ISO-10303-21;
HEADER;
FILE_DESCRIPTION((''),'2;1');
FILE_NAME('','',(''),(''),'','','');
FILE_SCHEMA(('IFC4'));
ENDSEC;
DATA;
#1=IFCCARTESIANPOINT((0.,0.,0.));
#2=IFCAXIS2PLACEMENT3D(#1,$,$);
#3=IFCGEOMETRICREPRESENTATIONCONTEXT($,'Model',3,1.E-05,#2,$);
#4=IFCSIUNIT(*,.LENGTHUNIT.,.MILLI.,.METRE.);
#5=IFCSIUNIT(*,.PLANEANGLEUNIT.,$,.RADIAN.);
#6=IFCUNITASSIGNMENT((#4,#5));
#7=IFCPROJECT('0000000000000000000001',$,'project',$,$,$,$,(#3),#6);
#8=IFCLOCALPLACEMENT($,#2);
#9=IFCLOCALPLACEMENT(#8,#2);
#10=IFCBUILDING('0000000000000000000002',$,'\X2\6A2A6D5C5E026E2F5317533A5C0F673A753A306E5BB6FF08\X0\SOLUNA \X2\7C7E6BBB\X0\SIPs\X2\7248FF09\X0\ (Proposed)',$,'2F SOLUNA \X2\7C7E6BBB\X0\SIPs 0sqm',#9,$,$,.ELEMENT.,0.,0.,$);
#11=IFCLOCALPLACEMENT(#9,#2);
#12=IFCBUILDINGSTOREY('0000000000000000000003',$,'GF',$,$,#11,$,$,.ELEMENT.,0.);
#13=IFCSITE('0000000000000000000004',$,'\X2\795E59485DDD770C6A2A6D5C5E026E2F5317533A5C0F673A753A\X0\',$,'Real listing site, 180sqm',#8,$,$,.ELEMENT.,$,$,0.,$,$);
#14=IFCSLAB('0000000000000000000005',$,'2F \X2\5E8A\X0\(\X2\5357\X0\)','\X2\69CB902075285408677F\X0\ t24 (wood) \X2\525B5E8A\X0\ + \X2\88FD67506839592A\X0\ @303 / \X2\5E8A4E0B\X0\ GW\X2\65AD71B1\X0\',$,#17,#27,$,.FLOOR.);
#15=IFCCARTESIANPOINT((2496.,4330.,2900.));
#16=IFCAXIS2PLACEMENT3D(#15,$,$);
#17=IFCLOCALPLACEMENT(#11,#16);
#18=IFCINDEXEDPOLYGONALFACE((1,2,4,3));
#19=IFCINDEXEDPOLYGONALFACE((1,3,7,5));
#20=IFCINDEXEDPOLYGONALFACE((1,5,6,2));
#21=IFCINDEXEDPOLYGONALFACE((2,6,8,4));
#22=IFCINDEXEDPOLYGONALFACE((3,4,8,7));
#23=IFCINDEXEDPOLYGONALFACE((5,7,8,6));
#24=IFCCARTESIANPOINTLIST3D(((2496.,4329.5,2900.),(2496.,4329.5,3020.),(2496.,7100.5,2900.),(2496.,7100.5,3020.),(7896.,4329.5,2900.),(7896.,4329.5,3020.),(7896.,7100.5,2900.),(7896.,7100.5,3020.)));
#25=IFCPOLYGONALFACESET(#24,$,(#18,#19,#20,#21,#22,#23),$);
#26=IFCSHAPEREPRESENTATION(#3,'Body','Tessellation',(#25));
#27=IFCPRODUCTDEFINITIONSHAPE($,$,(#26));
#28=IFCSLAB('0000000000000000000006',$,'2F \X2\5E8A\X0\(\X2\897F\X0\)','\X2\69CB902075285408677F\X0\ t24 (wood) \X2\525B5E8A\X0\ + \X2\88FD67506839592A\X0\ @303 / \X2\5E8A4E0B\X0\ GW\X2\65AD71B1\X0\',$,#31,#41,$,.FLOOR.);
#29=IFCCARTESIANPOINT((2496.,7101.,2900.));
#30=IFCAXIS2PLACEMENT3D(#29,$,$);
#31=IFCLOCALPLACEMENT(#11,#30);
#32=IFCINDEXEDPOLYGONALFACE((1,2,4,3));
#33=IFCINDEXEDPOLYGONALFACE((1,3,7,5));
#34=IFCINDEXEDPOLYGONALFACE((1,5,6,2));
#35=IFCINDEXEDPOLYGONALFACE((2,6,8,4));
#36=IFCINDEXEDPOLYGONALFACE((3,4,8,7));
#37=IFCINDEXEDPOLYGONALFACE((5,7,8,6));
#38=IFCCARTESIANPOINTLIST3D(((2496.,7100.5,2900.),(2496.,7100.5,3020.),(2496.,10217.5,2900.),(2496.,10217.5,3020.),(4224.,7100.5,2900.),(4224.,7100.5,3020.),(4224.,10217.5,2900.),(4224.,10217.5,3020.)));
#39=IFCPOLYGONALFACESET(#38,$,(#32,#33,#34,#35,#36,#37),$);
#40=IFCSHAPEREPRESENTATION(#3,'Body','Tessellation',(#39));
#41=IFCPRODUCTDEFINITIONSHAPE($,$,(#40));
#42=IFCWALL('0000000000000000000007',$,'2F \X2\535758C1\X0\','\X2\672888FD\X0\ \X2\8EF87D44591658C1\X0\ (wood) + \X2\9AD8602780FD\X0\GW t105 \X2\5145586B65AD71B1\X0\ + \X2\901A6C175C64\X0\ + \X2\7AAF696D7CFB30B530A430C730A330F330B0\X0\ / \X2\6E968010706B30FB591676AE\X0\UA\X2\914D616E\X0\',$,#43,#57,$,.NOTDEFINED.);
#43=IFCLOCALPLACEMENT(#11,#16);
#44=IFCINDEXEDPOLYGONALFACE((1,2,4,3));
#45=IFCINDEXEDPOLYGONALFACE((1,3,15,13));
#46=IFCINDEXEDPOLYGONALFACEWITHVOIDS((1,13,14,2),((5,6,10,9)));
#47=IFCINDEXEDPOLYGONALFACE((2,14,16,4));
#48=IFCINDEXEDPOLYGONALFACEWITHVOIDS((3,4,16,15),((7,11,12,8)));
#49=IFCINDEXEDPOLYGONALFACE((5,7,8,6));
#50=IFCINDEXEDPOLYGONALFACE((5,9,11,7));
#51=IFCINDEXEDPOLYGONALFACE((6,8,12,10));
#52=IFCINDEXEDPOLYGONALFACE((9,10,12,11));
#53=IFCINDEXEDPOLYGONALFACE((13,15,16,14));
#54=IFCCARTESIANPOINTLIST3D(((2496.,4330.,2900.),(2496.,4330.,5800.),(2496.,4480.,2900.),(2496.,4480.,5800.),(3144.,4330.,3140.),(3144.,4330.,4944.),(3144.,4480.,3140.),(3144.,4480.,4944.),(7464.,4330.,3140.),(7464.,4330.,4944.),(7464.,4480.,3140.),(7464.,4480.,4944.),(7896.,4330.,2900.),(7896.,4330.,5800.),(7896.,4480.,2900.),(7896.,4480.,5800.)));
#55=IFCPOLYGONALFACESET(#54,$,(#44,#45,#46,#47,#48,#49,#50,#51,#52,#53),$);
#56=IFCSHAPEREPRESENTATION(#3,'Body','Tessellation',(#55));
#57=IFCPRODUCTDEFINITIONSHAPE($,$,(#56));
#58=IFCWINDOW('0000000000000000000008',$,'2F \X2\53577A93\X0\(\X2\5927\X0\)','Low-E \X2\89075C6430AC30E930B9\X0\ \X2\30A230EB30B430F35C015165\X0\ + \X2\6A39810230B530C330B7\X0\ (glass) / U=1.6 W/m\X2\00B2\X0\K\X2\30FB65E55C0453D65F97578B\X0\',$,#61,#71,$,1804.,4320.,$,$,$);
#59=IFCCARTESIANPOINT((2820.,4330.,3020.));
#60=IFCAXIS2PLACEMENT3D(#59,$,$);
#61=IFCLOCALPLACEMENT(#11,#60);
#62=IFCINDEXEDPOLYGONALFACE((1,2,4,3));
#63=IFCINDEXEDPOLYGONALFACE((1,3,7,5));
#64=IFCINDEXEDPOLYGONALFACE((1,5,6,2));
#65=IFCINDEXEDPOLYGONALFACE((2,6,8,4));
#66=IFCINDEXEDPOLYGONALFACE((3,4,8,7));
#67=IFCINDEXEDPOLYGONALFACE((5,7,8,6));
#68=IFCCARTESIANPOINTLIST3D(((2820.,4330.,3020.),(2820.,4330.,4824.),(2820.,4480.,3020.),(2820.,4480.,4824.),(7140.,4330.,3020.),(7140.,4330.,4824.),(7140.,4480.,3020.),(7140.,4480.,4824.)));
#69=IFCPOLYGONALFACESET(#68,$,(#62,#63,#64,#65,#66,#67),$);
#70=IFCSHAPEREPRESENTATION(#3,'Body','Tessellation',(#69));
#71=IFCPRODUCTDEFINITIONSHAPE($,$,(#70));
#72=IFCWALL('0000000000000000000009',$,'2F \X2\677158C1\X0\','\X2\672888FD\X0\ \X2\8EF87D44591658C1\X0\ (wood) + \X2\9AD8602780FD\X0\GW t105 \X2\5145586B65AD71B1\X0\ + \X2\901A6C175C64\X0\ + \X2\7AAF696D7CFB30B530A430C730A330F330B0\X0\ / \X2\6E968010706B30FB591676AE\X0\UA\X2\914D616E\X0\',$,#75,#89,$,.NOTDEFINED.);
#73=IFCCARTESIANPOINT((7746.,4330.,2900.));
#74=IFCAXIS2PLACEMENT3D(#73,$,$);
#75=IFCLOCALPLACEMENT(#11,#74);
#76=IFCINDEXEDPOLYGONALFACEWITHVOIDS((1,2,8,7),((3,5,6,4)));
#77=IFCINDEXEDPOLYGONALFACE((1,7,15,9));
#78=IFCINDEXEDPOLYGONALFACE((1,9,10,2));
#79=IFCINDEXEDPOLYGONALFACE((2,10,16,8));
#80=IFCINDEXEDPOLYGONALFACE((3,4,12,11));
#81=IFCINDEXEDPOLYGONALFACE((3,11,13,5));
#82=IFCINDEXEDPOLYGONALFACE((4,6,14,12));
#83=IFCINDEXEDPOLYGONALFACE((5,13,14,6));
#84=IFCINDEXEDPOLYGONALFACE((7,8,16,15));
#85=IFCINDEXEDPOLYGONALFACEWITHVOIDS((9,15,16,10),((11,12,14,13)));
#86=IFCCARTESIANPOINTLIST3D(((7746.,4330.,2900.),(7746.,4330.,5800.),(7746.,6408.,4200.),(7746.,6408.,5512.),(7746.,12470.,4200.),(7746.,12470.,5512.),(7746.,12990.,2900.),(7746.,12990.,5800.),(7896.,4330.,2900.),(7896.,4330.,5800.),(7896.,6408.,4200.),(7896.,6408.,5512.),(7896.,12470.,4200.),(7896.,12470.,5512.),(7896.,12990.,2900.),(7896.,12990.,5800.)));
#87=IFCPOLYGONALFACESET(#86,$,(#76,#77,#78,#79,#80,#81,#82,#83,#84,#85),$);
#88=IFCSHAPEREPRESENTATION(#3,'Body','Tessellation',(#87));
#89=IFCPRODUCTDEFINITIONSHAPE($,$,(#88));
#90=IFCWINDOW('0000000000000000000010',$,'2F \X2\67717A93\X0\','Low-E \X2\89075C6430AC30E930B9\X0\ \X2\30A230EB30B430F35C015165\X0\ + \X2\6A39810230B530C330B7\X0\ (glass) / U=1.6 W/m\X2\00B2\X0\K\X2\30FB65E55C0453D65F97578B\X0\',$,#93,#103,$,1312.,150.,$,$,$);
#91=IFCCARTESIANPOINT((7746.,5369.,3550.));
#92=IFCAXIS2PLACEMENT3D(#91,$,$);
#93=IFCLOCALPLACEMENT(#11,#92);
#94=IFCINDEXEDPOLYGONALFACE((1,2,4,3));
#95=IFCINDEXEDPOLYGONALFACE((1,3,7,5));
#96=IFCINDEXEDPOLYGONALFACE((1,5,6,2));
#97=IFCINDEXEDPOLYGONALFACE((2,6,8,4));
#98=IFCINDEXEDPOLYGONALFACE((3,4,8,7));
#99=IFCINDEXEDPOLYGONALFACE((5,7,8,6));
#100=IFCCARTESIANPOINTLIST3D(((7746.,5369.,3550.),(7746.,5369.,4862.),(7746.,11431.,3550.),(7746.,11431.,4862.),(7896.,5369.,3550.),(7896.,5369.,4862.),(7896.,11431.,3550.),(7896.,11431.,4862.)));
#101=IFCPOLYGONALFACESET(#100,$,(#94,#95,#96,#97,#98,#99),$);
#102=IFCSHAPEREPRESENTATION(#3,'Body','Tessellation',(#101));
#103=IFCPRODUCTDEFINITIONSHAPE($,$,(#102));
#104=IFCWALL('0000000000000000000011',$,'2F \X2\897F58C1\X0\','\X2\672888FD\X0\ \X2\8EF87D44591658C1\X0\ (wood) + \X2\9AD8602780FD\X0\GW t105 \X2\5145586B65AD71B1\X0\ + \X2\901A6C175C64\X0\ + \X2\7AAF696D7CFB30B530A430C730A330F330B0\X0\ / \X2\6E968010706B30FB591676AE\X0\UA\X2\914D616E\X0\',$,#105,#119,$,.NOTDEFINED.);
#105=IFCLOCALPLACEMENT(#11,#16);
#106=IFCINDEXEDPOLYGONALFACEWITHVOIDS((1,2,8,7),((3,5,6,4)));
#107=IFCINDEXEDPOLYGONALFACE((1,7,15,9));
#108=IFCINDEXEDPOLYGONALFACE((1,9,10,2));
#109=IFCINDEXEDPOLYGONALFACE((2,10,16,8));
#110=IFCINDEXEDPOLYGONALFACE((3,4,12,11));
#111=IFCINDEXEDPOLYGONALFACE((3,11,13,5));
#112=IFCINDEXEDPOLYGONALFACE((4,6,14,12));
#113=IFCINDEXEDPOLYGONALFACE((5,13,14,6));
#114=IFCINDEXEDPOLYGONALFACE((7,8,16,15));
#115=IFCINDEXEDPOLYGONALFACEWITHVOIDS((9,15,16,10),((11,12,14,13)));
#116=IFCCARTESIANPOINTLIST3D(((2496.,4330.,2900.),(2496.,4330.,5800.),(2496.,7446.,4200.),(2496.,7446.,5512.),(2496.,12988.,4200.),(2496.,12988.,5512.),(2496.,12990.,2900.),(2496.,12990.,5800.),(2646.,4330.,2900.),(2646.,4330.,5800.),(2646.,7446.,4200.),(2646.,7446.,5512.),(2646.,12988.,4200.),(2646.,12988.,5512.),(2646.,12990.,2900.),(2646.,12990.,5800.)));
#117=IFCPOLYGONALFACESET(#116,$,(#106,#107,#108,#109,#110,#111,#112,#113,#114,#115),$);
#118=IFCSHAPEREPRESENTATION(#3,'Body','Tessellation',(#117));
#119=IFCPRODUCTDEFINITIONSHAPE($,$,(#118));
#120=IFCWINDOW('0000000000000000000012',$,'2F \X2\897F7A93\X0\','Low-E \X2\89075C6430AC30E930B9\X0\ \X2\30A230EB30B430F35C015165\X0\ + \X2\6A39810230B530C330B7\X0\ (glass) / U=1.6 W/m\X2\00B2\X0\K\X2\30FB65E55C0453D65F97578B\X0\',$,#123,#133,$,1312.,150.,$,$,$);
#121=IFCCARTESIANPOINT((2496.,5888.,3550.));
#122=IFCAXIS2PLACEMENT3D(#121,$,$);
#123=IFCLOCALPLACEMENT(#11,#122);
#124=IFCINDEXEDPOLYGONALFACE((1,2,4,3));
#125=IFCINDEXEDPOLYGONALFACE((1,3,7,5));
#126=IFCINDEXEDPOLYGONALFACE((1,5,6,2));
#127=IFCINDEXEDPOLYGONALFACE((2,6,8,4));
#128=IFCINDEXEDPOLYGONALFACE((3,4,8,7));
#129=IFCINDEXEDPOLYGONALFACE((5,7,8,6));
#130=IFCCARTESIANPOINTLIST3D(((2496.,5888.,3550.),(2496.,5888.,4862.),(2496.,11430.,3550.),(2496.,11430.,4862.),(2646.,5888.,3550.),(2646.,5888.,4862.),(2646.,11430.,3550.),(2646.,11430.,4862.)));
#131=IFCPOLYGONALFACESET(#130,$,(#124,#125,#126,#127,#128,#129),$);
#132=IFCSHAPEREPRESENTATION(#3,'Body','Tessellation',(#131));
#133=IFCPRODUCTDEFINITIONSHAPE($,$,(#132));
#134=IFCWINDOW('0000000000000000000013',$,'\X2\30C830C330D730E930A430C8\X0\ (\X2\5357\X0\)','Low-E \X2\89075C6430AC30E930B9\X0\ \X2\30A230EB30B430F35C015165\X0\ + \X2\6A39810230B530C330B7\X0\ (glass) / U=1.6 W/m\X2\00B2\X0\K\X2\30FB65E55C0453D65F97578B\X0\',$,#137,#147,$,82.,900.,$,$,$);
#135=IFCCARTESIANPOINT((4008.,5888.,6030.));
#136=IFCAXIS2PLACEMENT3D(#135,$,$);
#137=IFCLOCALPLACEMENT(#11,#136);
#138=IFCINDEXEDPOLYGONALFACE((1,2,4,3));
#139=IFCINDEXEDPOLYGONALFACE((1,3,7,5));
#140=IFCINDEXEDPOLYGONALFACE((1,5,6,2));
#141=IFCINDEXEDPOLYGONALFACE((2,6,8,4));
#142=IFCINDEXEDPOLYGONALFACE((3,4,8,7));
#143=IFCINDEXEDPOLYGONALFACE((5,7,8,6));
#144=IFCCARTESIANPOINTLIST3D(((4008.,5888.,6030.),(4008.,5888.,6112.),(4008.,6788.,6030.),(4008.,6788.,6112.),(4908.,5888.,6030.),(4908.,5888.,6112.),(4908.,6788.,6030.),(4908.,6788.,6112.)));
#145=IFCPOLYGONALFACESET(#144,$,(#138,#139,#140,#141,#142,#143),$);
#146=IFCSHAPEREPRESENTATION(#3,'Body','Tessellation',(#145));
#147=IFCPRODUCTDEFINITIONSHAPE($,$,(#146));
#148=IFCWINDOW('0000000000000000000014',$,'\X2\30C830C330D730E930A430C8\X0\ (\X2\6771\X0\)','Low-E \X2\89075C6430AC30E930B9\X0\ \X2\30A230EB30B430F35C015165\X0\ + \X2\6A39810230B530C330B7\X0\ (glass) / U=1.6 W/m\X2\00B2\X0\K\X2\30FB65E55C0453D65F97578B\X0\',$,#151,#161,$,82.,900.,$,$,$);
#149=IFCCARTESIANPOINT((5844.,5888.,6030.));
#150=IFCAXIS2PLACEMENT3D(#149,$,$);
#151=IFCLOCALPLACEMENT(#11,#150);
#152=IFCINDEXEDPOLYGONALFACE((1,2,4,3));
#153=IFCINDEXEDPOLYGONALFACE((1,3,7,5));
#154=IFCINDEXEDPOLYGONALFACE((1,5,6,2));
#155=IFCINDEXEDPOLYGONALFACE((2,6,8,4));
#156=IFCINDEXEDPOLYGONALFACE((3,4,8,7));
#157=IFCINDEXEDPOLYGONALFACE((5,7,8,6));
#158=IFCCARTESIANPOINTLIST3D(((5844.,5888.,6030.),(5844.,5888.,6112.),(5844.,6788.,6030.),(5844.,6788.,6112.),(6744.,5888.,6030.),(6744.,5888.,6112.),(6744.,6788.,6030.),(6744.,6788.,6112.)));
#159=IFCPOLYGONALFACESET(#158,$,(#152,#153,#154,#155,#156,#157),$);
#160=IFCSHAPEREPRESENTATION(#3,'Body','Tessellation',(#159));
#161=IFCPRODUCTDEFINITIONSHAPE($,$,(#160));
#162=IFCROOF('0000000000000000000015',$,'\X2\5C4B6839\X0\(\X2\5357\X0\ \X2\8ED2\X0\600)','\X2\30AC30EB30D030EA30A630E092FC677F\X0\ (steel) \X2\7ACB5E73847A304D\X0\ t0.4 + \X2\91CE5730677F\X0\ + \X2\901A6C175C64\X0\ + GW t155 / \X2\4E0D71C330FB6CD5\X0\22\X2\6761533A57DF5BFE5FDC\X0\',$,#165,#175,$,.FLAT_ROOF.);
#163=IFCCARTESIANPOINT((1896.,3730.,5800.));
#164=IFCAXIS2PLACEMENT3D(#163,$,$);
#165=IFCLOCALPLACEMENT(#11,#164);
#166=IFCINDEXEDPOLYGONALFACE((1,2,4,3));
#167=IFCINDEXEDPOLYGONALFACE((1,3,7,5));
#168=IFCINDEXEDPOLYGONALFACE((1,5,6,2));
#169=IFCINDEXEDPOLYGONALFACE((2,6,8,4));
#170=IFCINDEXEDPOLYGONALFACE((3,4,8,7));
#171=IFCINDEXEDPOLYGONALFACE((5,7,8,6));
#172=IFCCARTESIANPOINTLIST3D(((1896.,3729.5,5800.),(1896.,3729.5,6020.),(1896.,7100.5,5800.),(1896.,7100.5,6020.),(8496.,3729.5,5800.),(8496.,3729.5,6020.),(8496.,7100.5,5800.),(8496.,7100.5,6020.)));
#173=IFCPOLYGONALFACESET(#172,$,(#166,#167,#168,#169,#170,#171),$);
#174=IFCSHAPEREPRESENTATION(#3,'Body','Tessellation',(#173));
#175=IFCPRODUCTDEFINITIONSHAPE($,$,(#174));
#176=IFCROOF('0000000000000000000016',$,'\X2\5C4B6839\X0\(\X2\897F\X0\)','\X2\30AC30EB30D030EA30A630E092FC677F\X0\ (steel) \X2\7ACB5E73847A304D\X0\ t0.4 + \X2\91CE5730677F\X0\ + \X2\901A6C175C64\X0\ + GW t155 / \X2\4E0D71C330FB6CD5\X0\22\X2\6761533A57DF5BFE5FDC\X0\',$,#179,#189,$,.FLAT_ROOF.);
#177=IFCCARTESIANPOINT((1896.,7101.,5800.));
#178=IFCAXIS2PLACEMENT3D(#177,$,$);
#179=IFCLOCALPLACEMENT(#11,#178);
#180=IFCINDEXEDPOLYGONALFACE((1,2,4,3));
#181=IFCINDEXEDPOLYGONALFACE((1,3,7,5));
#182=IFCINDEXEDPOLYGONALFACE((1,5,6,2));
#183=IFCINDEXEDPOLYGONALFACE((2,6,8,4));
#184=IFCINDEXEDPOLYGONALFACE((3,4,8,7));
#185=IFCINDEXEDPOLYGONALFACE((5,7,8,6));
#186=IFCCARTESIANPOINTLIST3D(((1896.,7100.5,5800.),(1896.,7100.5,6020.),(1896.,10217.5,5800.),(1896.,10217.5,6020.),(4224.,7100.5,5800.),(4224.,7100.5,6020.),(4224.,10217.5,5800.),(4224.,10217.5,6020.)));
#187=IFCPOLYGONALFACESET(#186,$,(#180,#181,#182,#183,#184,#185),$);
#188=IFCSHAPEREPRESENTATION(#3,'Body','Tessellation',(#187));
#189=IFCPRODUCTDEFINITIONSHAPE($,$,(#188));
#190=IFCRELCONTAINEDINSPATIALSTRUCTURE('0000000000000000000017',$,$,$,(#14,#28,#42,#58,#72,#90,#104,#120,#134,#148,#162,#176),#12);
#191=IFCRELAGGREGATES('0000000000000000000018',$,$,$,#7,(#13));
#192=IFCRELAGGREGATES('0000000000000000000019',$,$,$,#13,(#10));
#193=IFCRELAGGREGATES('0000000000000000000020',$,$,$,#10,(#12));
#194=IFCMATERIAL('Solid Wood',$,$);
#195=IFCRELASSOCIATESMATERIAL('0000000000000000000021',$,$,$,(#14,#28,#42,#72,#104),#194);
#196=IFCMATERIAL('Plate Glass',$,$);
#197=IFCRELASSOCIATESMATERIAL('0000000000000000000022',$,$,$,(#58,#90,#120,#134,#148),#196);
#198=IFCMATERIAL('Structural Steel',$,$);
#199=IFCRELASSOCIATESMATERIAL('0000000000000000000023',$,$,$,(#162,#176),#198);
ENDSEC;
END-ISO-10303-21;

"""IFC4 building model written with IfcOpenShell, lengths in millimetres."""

from ifc_helpers import new_model, si_unit, frame, frame_2d, origin, place, context, project, spatial, rectangle, extrude, material, element, fill, save


model = new_model("IFC4")

# Units and contexts
model_context = context("Model", 3, precision=1e-05, world=origin())
ifc_project = project(units=[si_unit("LENGTHUNIT", "METRE", prefix="MILLI"), si_unit("PLANEANGLEUNIT", "RADIAN")], contexts=[model_context])

# Site, building, storey
site_placement = place(None, origin())
site = spatial("IfcSite", under=ifc_project, at=site_placement, Name="神奈川県横浜市港北区小机町", ObjectType="Real listing site, 180sqm", CompositionType="ELEMENT", RefElevation=0.0)
building_placement = place(site_placement, origin())
building = spatial("IfcBuilding", under=site, at=building_placement, Name="横浜市港北区小机町の家（SOLUNA 籾殻SIPs版） (Proposed)", ObjectType="2F SOLUNA 籾殻SIPs 0sqm", CompositionType="ELEMENT", ElevationOfRefHeight=0.0, ElevationOfTerrain=0.0)
storey_placement = place(building_placement, origin())
storey = spatial("IfcBuildingStorey", under=building, at=storey_placement, Name="GF", CompositionType="ELEMENT", Elevation=0.0)

# Slabs
ifc_material_1 = material(Name="Solid Wood")
slab_1_placement = place(storey_placement, frame((2496.0, 4330.0, 2900.0)))
element("IfcSlab", 1, at=slab_1_placement, inside=storey, material=ifc_material_1, Name="2F 床(南)", Description="構造用合板 t24 (wood) 剛床 + 製材根太 @303 / 床下 GW断熱", PredefinedType="FLOOR", context=model_context, shape_type="SweptSolid", body=[
    extrude(rectangle(XDim=5400.0, YDim=2771.0, at=frame_2d((2700.0, 1385.0))), frame((2496.0, 4330.0, 2900.0)), (0.0, 0.0, 1.0), 120.0),
])
slab_2_placement = place(storey_placement, frame((2496.0, 7101.0, 2900.0)))
element("IfcSlab", 2, at=slab_2_placement, inside=storey, material=ifc_material_1, Name="2F 床(西)", Description="構造用合板 t24 (wood) 剛床 + 製材根太 @303 / 床下 GW断熱", PredefinedType="FLOOR", context=model_context, shape_type="SweptSolid", body=[
    extrude(rectangle(XDim=1728.0, YDim=3117.0, at=frame_2d((864.0, 1558.0))), frame((2496.0, 7101.0, 2900.0)), (0.0, 0.0, 1.0), 120.0),
])

# Walls, openings, windows
wall_1_placement = place(storey_placement, frame((2496.0, 4330.0, 2900.0)))
wall_1 = element("IfcWall", 3, at=wall_1_placement, inside=storey, material=ifc_material_1, Name="2F 南壁", Description="木製 軸組外壁 (wood) + 高性能GW t105 充填断熱 + 通気層 + 窯業系サイディング / 準耐火・外皮UA配慮", PredefinedType="NOTDEFINED", context=model_context, shape_type="SweptSolid", body=[
    extrude(rectangle(XDim=5400.0, YDim=150.0, at=frame_2d((2700.0, 75.0))), frame((2496.0, 4330.0, 2900.0)), (0.0, 0.0, 1.0), 2900.0),
])
opening_1_placement = place(storey_placement, frame((2820.0, 4330.0, 3020.0)))
opening_1 = element("IfcOpeningElement", 4, at=opening_1_placement, cuts=wall_1, PredefinedType="NOTDEFINED", context=model_context, shape_type="SweptSolid", body=[
    extrude(rectangle(XDim=4320.0, YDim=150.0, at=frame_2d((2160.0, 75.0))), frame((2820.0, 4330.0, 3020.0)), (0.0, 0.0, 1.0), 1804.0),
])
ifc_material_2 = material(Name="Plate Glass")
window_1_placement = place(storey_placement, frame((2820.0, 4330.0, 3020.0)))
window_1 = element("IfcWindow", 5, at=window_1_placement, inside=storey, material=ifc_material_2, Name="2F 南窓(大)", Description="Low-E 複層ガラス アルゴン封入 + 樹脂サッシ (glass) / U=1.6 W/m²K・日射取得型", OverallHeight=1804.0, OverallWidth=4320.0, context=model_context, shape_type="SweptSolid", body=[
    extrude(rectangle(XDim=4320.0, YDim=150.0, at=frame_2d((2160.0, 75.0))), frame((2820.0, 4330.0, 3020.0)), (0.0, 0.0, 1.0), 1804.0),
])
fill(opening_1, window_1)
wall_2_placement = place(storey_placement, frame((7746.0, 4330.0, 2900.0)))
wall_2 = element("IfcWall", 6, at=wall_2_placement, inside=storey, material=ifc_material_1, Name="2F 東壁", Description="木製 軸組外壁 (wood) + 高性能GW t105 充填断熱 + 通気層 + 窯業系サイディング / 準耐火・外皮UA配慮", PredefinedType="NOTDEFINED", context=model_context, shape_type="SweptSolid", body=[
    extrude(rectangle(XDim=150.0, YDim=8660.0, at=frame_2d((75.0, 4330.0))), frame((7746.0, 4330.0, 2900.0)), (0.0, 0.0, 1.0), 2900.0),
])
opening_2_placement = place(storey_placement, frame((7746.0, 5369.0, 3550.0)))
opening_2 = element("IfcOpeningElement", 7, at=opening_2_placement, cuts=wall_2, PredefinedType="NOTDEFINED", context=model_context, shape_type="SweptSolid", body=[
    extrude(rectangle(XDim=150.0, YDim=6062.0, at=frame_2d((75.0, 3031.0))), frame((7746.0, 5369.0, 3550.0)), (0.0, 0.0, 1.0), 1312.0),
])
window_2_placement = place(storey_placement, frame((7746.0, 5369.0, 3550.0)))
window_2 = element("IfcWindow", 8, at=window_2_placement, inside=storey, material=ifc_material_2, Name="2F 東窓", Description="Low-E 複層ガラス アルゴン封入 + 樹脂サッシ (glass) / U=1.6 W/m²K・日射取得型", OverallHeight=1312.0, OverallWidth=150.0, context=model_context, shape_type="SweptSolid", body=[
    extrude(rectangle(XDim=150.0, YDim=6062.0, at=frame_2d((75.0, 3031.0))), frame((7746.0, 5369.0, 3550.0)), (0.0, 0.0, 1.0), 1312.0),
])
fill(opening_2, window_2)
wall_3_placement = place(storey_placement, frame((2496.0, 4330.0, 2900.0)))
wall_3 = element("IfcWall", 9, at=wall_3_placement, inside=storey, material=ifc_material_1, Name="2F 西壁", Description="木製 軸組外壁 (wood) + 高性能GW t105 充填断熱 + 通気層 + 窯業系サイディング / 準耐火・外皮UA配慮", PredefinedType="NOTDEFINED", context=model_context, shape_type="SweptSolid", body=[
    extrude(rectangle(XDim=150.0, YDim=8660.0, at=frame_2d((75.0, 4330.0))), frame((2496.0, 4330.0, 2900.0)), (0.0, 0.0, 1.0), 2900.0),
])
opening_3_placement = place(storey_placement, frame((2496.0, 5888.0, 3550.0)))
opening_3 = element("IfcOpeningElement", 10, at=opening_3_placement, cuts=wall_3, PredefinedType="NOTDEFINED", context=model_context, shape_type="SweptSolid", body=[
    extrude(rectangle(XDim=150.0, YDim=5542.0, at=frame_2d((75.0, 2771.0))), frame((2496.0, 5888.0, 3550.0)), (0.0, 0.0, 1.0), 1312.0),
])
window_3_placement = place(storey_placement, frame((2496.0, 5888.0, 3550.0)))
window_3 = element("IfcWindow", 11, at=window_3_placement, inside=storey, material=ifc_material_2, Name="2F 西窓", Description="Low-E 複層ガラス アルゴン封入 + 樹脂サッシ (glass) / U=1.6 W/m²K・日射取得型", OverallHeight=1312.0, OverallWidth=150.0, context=model_context, shape_type="SweptSolid", body=[
    extrude(rectangle(XDim=150.0, YDim=5542.0, at=frame_2d((75.0, 2771.0))), frame((2496.0, 5888.0, 3550.0)), (0.0, 0.0, 1.0), 1312.0),
])
fill(opening_3, window_3)

# Windows
window_4_placement = place(storey_placement, frame((4008.0, 5888.0, 6030.0)))
element("IfcWindow", 12, at=window_4_placement, inside=storey, material=ifc_material_2, Name="トップライト (南)", Description="Low-E 複層ガラス アルゴン封入 + 樹脂サッシ (glass) / U=1.6 W/m²K・日射取得型", OverallHeight=82.0, OverallWidth=900.0, context=model_context, shape_type="SweptSolid", body=[
    extrude(rectangle(XDim=900.0, YDim=900.0, at=frame_2d((450.0, 450.0))), frame((4008.0, 5888.0, 6030.0)), (0.0, 0.0, 1.0), 82.0),
])
window_5_placement = place(storey_placement, frame((5844.0, 5888.0, 6030.0)))
element("IfcWindow", 13, at=window_5_placement, inside=storey, material=ifc_material_2, Name="トップライト (東)", Description="Low-E 複層ガラス アルゴン封入 + 樹脂サッシ (glass) / U=1.6 W/m²K・日射取得型", OverallHeight=82.0, OverallWidth=900.0, context=model_context, shape_type="SweptSolid", body=[
    extrude(rectangle(XDim=900.0, YDim=900.0, at=frame_2d((450.0, 450.0))), frame((5844.0, 5888.0, 6030.0)), (0.0, 0.0, 1.0), 82.0),
])

# Roofs
ifc_material_3 = material(Name="Structural Steel")
roof_1_placement = place(storey_placement, frame((1896.0, 3730.0, 5800.0)))
element("IfcRoof", 14, at=roof_1_placement, inside=storey, material=ifc_material_3, Name="屋根(南 軒600)", Description="ガルバリウム鋼板 (steel) 立平葺き t0.4 + 野地板 + 通気層 + GW t155 / 不燃・法22条区域対応", PredefinedType="FLAT_ROOF", context=model_context, shape_type="SweptSolid", body=[
    extrude(rectangle(XDim=6600.0, YDim=3371.0, at=frame_2d((3300.0, 1685.0))), frame((1896.0, 3730.0, 5800.0)), (0.0, 0.0, 1.0), 220.0),
])
roof_2_placement = place(storey_placement, frame((1896.0, 7101.0, 5800.0)))
element("IfcRoof", 15, at=roof_2_placement, inside=storey, material=ifc_material_3, Name="屋根(西)", Description="ガルバリウム鋼板 (steel) 立平葺き t0.4 + 野地板 + 通気層 + GW t155 / 不燃・法22条区域対応", PredefinedType="FLAT_ROOF", context=model_context, shape_type="SweptSolid", body=[
    extrude(rectangle(XDim=2328.0, YDim=3117.0, at=frame_2d((1164.0, 1558.0))), frame((1896.0, 7101.0, 5800.0)), (0.0, 0.0, 1.0), 220.0),
])

save(model, "model.ifc")
